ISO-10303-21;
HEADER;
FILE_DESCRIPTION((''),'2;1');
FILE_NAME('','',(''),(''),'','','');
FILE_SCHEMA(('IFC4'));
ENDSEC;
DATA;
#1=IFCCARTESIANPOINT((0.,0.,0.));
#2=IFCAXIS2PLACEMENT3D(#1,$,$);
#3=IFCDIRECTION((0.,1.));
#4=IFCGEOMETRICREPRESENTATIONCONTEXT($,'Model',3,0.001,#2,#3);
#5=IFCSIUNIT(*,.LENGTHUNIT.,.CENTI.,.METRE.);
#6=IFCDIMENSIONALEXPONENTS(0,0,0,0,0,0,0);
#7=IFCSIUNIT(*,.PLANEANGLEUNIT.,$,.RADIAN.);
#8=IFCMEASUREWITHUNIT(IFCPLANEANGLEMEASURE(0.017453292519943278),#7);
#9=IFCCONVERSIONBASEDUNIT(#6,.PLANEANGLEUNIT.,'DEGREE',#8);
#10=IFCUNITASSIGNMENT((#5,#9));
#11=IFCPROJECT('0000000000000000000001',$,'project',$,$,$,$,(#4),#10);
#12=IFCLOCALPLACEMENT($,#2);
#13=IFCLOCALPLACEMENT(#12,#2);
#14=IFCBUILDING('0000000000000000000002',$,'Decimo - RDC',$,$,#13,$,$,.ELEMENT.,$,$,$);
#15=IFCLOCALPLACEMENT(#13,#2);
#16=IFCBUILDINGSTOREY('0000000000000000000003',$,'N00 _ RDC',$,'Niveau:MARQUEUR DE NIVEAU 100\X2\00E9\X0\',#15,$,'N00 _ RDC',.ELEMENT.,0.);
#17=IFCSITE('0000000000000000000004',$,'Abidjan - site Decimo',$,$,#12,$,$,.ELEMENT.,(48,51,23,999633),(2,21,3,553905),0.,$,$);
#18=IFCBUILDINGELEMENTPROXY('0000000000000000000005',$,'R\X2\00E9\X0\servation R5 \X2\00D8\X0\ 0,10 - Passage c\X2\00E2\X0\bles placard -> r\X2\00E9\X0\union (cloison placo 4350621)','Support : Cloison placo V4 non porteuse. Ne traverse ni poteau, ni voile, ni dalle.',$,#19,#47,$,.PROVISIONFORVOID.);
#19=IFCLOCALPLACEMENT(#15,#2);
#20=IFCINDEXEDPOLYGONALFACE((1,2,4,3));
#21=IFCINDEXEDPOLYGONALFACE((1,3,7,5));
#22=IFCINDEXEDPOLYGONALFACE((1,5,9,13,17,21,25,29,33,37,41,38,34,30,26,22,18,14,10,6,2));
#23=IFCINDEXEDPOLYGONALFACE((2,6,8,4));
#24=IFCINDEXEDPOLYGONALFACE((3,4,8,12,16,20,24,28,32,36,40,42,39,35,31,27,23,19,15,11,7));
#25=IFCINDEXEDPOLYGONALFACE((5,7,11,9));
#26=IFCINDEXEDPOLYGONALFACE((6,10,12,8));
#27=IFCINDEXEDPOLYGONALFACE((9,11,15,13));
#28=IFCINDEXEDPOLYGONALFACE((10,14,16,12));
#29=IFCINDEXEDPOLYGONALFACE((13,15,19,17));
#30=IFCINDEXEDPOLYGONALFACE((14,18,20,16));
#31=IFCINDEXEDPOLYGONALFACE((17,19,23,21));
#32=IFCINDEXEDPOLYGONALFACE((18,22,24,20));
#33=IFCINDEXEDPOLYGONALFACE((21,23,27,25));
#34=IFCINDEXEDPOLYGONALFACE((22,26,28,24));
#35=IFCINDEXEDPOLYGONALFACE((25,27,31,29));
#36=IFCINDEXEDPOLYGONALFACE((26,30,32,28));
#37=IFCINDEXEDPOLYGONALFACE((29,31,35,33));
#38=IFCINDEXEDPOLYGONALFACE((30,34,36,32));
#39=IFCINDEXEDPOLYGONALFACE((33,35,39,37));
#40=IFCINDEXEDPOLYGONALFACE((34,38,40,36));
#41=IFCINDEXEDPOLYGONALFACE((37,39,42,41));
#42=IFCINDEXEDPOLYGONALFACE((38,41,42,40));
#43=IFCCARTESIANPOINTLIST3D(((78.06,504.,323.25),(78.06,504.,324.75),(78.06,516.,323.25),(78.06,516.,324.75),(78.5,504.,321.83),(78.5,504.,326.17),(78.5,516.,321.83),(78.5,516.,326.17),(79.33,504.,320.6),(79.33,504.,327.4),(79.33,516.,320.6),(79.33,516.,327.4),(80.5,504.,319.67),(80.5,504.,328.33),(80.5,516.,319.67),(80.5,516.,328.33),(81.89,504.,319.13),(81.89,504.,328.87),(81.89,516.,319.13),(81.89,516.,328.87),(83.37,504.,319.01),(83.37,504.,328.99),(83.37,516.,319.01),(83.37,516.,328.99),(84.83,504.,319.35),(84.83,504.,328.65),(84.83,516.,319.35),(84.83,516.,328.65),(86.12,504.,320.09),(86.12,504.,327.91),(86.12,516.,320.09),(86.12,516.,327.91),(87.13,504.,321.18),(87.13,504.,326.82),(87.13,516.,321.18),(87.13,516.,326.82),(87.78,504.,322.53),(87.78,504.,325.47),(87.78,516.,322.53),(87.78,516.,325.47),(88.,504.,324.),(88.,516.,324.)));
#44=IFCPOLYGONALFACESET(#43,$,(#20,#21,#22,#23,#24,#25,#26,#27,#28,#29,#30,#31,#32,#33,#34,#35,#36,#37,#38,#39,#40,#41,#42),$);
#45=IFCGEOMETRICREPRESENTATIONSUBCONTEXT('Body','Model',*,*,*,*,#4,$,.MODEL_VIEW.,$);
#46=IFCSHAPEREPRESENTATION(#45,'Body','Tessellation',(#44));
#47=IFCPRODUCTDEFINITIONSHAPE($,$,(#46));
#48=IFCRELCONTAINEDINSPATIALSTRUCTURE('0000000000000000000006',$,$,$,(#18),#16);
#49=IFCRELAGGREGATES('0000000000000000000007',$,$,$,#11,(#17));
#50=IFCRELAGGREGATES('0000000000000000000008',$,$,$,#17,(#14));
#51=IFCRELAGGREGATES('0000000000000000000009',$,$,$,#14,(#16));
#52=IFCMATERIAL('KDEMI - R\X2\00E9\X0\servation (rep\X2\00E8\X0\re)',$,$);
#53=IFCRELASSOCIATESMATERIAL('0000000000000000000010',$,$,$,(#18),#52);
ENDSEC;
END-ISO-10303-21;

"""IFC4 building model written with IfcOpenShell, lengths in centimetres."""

from ifc_helpers import new_model, entity, si_unit, converted_unit, direction, frame, origin, origin_with_axes, origin_2d, place, context, subcontext, project, spatial, circle, extrude, material, element, save


model = new_model("IFC4")

# Units and contexts
model_context = context("Model", 3, precision=0.001, world=origin(), true_north=direction((0.0, 1.0)))
body_context = subcontext(model_context, "Body", "Model", "MODEL_VIEW")
ifc_project = project(units=[si_unit("LENGTHUNIT", "METRE", prefix="CENTI"), converted_unit("PLANEANGLEUNIT", "DEGREE", entity("IfcPlaneAngleMeasure", 0.017453292519943278), si_unit("PLANEANGLEUNIT", "RADIAN"), dimensions=[0, 0, 0, 0, 0, 0, 0])], contexts=[model_context])

# Site, building, storey
site_placement = place(None, origin())
site = spatial("IfcSite", under=ifc_project, at=site_placement, Name="Abidjan - site Decimo", CompositionType="ELEMENT", RefLatitude=(48, 51, 23, 999633), RefLongitude=(2, 21, 3, 553905), RefElevation=0.0)
building_placement = place(site_placement, origin())
building = spatial("IfcBuilding", under=site, at=building_placement, Name="Decimo - RDC", CompositionType="ELEMENT")
storey_placement = place(building_placement, origin())
storey = spatial("IfcBuildingStorey", under=building, at=storey_placement, Name="N00 _ RDC", ObjectType="Niveau:MARQUEUR DE NIVEAU 100é", LongName="N00 _ RDC", CompositionType="ELEMENT", Elevation=0.0)

# Building element proxy
ifc_material_1 = material(Name="KDEMI - Réservation (repère)")
proxy_1_placement = place(storey_placement, origin_with_axes())
element("IfcBuildingElementProxy", 1, at=proxy_1_placement, inside=storey, material=ifc_material_1, Name="Réservation R5 Ø 0,10 - Passage câbles placard -> réunion (cloison placo 4350621)", Description="Support : Cloison placo V4 non porteuse. Ne traverse ni poteau, ni voile, ni dalle.", PredefinedType="PROVISIONFORVOID", context=body_context, shape_type="SweptSolid", body=[
    extrude(circle(Radius=5.0, at=origin_2d()), frame((83.0, 504.0, 324.0), z_axis=(0.0, 1.0, 0.0), x_axis=(1.0, 0.0, 0.0)), (0.0, 0.0, 1.0), 12.0),
])

save(model, "model.ifc")
